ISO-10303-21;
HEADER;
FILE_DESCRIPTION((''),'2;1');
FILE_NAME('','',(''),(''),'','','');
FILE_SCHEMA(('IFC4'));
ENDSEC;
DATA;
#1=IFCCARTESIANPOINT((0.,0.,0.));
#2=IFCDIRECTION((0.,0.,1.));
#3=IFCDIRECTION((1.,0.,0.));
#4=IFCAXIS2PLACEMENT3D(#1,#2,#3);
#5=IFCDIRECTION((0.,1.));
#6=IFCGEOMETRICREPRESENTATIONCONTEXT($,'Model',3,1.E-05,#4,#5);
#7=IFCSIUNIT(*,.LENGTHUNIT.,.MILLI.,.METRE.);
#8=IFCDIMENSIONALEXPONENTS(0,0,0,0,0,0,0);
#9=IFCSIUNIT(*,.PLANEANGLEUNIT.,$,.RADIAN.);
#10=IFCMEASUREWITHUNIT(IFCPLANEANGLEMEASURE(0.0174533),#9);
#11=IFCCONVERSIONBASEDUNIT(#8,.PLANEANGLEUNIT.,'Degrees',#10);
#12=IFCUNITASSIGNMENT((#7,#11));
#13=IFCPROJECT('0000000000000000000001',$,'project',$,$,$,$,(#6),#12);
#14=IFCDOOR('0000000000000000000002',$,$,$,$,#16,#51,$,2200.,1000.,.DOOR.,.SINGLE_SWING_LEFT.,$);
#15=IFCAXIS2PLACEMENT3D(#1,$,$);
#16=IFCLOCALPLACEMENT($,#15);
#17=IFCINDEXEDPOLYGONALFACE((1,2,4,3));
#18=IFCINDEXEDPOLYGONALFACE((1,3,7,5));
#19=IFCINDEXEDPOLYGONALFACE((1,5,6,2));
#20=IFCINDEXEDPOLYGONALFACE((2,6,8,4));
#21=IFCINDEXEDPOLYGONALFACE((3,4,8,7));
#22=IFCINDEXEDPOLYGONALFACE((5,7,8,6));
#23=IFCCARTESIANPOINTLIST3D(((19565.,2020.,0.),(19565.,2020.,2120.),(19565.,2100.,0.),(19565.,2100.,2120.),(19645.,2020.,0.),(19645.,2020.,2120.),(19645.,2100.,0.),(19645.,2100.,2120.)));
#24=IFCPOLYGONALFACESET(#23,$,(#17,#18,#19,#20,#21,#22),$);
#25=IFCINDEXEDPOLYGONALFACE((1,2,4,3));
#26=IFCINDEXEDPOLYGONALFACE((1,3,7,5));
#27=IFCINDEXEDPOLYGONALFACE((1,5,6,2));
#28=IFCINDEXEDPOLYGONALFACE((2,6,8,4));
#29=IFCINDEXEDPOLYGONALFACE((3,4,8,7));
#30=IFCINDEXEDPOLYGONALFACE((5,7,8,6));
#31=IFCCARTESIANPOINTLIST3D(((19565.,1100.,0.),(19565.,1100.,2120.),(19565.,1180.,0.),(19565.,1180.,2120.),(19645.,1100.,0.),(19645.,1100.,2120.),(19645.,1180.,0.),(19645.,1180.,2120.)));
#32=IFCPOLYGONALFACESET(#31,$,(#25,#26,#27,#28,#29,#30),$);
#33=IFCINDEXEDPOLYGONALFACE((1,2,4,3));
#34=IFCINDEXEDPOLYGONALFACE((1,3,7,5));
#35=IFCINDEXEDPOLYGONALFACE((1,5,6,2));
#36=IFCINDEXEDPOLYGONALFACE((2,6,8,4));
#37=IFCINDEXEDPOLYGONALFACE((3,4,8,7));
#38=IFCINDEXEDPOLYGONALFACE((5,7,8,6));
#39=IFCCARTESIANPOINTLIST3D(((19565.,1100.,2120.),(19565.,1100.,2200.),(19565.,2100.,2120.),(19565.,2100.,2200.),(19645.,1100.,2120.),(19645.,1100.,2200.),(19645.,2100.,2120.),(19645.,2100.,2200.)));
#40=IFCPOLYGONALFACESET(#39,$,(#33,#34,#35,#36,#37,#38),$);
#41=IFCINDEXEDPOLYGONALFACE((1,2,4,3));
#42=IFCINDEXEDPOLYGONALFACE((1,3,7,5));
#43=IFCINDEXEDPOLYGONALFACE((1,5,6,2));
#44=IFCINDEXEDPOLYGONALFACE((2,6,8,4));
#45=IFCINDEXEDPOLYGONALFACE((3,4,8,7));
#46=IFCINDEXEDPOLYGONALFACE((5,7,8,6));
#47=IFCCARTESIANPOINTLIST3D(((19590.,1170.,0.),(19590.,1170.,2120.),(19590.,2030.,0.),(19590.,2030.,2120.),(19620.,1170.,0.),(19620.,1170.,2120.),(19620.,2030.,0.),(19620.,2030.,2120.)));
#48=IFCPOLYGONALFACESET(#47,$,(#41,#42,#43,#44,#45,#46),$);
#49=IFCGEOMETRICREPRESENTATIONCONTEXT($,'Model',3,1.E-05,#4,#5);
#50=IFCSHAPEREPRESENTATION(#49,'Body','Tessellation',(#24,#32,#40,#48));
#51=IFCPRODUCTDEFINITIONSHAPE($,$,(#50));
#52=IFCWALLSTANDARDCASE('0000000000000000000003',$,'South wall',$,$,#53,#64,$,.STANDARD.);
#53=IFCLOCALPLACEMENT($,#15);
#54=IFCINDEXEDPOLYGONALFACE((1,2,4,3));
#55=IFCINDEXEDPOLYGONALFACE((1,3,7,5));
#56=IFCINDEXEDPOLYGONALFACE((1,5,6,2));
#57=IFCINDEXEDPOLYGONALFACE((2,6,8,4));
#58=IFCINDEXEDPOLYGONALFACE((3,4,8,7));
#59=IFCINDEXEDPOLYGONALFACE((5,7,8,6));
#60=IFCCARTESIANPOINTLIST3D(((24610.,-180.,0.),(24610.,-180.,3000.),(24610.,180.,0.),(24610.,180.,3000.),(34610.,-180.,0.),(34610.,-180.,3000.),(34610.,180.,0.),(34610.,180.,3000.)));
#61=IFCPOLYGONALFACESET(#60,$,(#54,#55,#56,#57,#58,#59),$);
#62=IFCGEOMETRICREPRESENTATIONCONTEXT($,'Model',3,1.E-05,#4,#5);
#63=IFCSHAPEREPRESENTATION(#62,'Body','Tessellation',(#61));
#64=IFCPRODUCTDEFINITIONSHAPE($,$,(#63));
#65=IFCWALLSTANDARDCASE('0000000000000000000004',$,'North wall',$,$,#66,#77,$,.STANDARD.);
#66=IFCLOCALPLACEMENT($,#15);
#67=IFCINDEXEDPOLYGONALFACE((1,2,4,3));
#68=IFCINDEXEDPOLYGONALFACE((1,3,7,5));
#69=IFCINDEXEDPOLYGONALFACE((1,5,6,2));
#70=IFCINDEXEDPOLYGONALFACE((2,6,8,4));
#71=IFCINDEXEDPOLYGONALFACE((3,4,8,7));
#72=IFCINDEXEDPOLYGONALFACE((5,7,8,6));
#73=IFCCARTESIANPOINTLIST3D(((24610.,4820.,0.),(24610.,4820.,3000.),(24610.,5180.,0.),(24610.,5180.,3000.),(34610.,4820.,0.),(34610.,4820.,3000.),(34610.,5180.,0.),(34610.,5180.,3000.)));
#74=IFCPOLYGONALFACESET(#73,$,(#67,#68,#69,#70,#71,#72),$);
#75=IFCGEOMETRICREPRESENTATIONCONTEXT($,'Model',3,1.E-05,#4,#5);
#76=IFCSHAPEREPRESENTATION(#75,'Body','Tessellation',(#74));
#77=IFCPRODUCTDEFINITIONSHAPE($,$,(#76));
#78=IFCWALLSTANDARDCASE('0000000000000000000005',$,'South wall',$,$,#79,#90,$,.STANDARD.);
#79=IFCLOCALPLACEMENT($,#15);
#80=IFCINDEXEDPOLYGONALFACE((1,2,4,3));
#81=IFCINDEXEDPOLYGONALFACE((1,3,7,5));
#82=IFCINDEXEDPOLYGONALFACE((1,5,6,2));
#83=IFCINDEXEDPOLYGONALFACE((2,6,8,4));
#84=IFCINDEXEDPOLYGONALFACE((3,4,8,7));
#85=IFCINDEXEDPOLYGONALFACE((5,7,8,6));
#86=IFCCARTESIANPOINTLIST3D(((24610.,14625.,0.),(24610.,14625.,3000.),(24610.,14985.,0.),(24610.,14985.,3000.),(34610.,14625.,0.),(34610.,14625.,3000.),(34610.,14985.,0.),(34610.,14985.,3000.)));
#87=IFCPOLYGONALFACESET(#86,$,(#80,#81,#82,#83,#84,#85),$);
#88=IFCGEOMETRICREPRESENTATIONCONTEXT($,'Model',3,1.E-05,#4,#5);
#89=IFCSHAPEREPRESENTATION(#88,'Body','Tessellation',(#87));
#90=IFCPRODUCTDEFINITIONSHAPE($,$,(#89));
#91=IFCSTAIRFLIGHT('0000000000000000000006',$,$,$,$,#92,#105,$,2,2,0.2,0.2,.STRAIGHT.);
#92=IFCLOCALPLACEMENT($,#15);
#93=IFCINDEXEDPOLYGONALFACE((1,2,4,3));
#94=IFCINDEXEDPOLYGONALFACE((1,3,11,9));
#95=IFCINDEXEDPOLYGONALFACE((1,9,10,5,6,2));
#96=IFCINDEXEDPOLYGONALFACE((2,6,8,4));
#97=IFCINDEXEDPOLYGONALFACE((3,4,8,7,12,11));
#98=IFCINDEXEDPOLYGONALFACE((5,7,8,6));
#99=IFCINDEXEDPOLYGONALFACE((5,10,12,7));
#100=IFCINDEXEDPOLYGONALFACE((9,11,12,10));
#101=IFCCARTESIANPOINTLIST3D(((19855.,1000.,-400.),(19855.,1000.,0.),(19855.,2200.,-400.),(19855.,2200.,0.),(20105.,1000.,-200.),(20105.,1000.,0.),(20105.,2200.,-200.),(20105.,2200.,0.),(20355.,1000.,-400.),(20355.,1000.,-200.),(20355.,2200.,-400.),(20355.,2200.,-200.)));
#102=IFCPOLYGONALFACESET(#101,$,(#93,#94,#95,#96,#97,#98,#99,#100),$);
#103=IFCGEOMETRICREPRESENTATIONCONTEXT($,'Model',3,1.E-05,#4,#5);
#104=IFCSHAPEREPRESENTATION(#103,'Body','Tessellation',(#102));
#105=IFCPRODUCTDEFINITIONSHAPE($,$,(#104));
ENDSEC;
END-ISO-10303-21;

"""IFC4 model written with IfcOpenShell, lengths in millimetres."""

from ifc_helpers import new_model, entity, si_unit, converted_unit, direction, frame, origin_with_axes, place, context, project, polyline, outline, extrude, element, save


model = new_model("IFC4")

# Units and contexts
model_context_1 = context("Model", 3, precision=1e-05, world=origin_with_axes(), true_north=direction((0.0, 1.0)))
model_context_2 = context("Model", 3, precision=1e-05, world=origin_with_axes(), true_north=direction((0.0, 1.0)))
model_context_3 = context("Model", 3, precision=1e-05, world=origin_with_axes(), true_north=direction((0.0, 1.0)))
model_context_4 = context("Model", 3, precision=1e-05, world=origin_with_axes(), true_north=direction((0.0, 1.0)))
model_context_5 = context("Model", 3, precision=1e-05, world=origin_with_axes(), true_north=direction((0.0, 1.0)))
model_context_6 = context("Model", 3, precision=1e-05, world=origin_with_axes(), true_north=direction((0.0, 1.0)))
ifc_project = project(units=[si_unit("LENGTHUNIT", "METRE", prefix="MILLI"), converted_unit("PLANEANGLEUNIT", "Degrees", entity("IfcPlaneAngleMeasure", 0.0174533), si_unit("PLANEANGLEUNIT", "RADIAN"), dimensions=[0, 0, 0, 0, 0, 0, 0])], contexts=[model_context_1])

# Shared definitions
placement_1 = place(None, frame((29610.0, 0.0, 0.0)))

# Shared definitions
placement_2 = place(None, frame((14805.0, 0.0, 0.0)))
placement_3 = place(None, frame((29610.0, 14805.0, 0.0)))

# Door
door_placement = place(placement_2, frame((4800.0, 1600.0, 0.0), z_axis=(0.0, 0.0, 1.0), x_axis=(0.0, 1.0, 0.0)))
element("IfcDoor", 1, at=door_placement, OperationType="SINGLE_SWING_LEFT", OverallHeight=2200.0, OverallWidth=1000.0, PredefinedType="DOOR", context=model_context_2, shape_type="SweptSolid", body=[
    extrude(outline(polyline([(-40.0, -40.0), (40.0, -40.0), (40.0, 40.0), (-40.0, 40.0), (-40.0, -40.0), (-40.0, -40.0)])), frame((460.0, 0.0, 0.0), z_axis=(0.0, 0.0, 1.0), x_axis=(1.0, 0.0, 0.0)), (0.0, 0.0, 1.0), 2120.0),
    extrude(outline(polyline([(-40.0, -40.0), (40.0, -40.0), (40.0, 40.0), (-40.0, 40.0), (-40.0, -40.0), (-40.0, -40.0)])), frame((-460.0, 0.0, 0.0), z_axis=(0.0, 0.0, 1.0), x_axis=(1.0, 0.0, 0.0)), (0.0, 0.0, 1.0), 2120.0),
    extrude(outline(polyline([(-500.0, -40.0), (500.0, -40.0), (500.0, 40.0), (-500.0, 40.0), (-500.0, -40.0), (-500.0, -40.0)])), frame((0.0, 0.0, 2120.0), z_axis=(0.0, 0.0, 1.0), x_axis=(1.0, 0.0, 0.0)), (0.0, 0.0, 1.0), 80.0),
    extrude(outline(polyline([(-430.0, -15.0), (430.0, -15.0), (430.0, 15.0), (-430.0, 15.0), (-430.0, -15.0), (-430.0, -15.0)])), origin_with_axes(), (0.0, 0.0, 1.0), 2120.0),
])

# Walls
wall_1_placement = place(placement_1, origin_with_axes())
element("IfcWallStandardCase", 2, at=wall_1_placement, Name="South wall", PredefinedType="STANDARD", context=model_context_4, shape_type="SweptSolid", body=[
    extrude(outline(polyline([(-5000.0, -180.0), (5000.0, -180.0), (5000.0, 180.0), (-5000.0, 180.0), (-5000.0, -180.0), (-5000.0, -180.0)])), origin_with_axes(), (0.0, 0.0, 1.0), 3000.0),
])
wall_2_placement = place(placement_1, frame((0.0, 5000.0, 0.0), z_axis=(0.0, 0.0, 1.0), x_axis=(1.0, 0.0, 0.0)))
element("IfcWallStandardCase", 3, at=wall_2_placement, Name="North wall", PredefinedType="STANDARD", context=model_context_5, shape_type="SweptSolid", body=[
    extrude(outline(polyline([(-5000.0, -180.0), (5000.0, -180.0), (5000.0, 180.0), (-5000.0, 180.0), (-5000.0, -180.0), (-5000.0, -180.0)])), origin_with_axes(), (0.0, 0.0, 1.0), 3000.0),
])
wall_3_placement = place(placement_3, origin_with_axes())
element("IfcWallStandardCase", 4, at=wall_3_placement, Name="South wall", PredefinedType="STANDARD", context=model_context_6, shape_type="SweptSolid", body=[
    extrude(outline(polyline([(-5000.0, -180.0), (5000.0, -180.0), (5000.0, 180.0), (-5000.0, 180.0), (-5000.0, -180.0), (-5000.0, -180.0)])), origin_with_axes(), (0.0, 0.0, 1.0), 3000.0),
])

# Stair flight
stair_flight_placement = place(placement_2, frame((5050.0, 1000.0, 0.0), z_axis=(0.0, 1.0, 0.0), x_axis=(1.0, 0.0, 0.0)))
element("IfcStairFlight", 5, at=stair_flight_placement, NumberOfRisers=2, NumberOfTreads=2, PredefinedType="STRAIGHT", RiserHeight=0.2, TreadLength=0.2, context=model_context_3, shape_type="SweptSolid", body=[
    extrude(outline(polyline([(0.0, 0.0), (250.0, 0.0), (250.0, 200.0), (500.0, 200.0), (500.0, 400.0), (0.0, 400.0), (0.0, 0.0)])), origin_with_axes(), (0.0, 0.0, 1.0), 1200.0),
])

save(model, "model.ifc")
